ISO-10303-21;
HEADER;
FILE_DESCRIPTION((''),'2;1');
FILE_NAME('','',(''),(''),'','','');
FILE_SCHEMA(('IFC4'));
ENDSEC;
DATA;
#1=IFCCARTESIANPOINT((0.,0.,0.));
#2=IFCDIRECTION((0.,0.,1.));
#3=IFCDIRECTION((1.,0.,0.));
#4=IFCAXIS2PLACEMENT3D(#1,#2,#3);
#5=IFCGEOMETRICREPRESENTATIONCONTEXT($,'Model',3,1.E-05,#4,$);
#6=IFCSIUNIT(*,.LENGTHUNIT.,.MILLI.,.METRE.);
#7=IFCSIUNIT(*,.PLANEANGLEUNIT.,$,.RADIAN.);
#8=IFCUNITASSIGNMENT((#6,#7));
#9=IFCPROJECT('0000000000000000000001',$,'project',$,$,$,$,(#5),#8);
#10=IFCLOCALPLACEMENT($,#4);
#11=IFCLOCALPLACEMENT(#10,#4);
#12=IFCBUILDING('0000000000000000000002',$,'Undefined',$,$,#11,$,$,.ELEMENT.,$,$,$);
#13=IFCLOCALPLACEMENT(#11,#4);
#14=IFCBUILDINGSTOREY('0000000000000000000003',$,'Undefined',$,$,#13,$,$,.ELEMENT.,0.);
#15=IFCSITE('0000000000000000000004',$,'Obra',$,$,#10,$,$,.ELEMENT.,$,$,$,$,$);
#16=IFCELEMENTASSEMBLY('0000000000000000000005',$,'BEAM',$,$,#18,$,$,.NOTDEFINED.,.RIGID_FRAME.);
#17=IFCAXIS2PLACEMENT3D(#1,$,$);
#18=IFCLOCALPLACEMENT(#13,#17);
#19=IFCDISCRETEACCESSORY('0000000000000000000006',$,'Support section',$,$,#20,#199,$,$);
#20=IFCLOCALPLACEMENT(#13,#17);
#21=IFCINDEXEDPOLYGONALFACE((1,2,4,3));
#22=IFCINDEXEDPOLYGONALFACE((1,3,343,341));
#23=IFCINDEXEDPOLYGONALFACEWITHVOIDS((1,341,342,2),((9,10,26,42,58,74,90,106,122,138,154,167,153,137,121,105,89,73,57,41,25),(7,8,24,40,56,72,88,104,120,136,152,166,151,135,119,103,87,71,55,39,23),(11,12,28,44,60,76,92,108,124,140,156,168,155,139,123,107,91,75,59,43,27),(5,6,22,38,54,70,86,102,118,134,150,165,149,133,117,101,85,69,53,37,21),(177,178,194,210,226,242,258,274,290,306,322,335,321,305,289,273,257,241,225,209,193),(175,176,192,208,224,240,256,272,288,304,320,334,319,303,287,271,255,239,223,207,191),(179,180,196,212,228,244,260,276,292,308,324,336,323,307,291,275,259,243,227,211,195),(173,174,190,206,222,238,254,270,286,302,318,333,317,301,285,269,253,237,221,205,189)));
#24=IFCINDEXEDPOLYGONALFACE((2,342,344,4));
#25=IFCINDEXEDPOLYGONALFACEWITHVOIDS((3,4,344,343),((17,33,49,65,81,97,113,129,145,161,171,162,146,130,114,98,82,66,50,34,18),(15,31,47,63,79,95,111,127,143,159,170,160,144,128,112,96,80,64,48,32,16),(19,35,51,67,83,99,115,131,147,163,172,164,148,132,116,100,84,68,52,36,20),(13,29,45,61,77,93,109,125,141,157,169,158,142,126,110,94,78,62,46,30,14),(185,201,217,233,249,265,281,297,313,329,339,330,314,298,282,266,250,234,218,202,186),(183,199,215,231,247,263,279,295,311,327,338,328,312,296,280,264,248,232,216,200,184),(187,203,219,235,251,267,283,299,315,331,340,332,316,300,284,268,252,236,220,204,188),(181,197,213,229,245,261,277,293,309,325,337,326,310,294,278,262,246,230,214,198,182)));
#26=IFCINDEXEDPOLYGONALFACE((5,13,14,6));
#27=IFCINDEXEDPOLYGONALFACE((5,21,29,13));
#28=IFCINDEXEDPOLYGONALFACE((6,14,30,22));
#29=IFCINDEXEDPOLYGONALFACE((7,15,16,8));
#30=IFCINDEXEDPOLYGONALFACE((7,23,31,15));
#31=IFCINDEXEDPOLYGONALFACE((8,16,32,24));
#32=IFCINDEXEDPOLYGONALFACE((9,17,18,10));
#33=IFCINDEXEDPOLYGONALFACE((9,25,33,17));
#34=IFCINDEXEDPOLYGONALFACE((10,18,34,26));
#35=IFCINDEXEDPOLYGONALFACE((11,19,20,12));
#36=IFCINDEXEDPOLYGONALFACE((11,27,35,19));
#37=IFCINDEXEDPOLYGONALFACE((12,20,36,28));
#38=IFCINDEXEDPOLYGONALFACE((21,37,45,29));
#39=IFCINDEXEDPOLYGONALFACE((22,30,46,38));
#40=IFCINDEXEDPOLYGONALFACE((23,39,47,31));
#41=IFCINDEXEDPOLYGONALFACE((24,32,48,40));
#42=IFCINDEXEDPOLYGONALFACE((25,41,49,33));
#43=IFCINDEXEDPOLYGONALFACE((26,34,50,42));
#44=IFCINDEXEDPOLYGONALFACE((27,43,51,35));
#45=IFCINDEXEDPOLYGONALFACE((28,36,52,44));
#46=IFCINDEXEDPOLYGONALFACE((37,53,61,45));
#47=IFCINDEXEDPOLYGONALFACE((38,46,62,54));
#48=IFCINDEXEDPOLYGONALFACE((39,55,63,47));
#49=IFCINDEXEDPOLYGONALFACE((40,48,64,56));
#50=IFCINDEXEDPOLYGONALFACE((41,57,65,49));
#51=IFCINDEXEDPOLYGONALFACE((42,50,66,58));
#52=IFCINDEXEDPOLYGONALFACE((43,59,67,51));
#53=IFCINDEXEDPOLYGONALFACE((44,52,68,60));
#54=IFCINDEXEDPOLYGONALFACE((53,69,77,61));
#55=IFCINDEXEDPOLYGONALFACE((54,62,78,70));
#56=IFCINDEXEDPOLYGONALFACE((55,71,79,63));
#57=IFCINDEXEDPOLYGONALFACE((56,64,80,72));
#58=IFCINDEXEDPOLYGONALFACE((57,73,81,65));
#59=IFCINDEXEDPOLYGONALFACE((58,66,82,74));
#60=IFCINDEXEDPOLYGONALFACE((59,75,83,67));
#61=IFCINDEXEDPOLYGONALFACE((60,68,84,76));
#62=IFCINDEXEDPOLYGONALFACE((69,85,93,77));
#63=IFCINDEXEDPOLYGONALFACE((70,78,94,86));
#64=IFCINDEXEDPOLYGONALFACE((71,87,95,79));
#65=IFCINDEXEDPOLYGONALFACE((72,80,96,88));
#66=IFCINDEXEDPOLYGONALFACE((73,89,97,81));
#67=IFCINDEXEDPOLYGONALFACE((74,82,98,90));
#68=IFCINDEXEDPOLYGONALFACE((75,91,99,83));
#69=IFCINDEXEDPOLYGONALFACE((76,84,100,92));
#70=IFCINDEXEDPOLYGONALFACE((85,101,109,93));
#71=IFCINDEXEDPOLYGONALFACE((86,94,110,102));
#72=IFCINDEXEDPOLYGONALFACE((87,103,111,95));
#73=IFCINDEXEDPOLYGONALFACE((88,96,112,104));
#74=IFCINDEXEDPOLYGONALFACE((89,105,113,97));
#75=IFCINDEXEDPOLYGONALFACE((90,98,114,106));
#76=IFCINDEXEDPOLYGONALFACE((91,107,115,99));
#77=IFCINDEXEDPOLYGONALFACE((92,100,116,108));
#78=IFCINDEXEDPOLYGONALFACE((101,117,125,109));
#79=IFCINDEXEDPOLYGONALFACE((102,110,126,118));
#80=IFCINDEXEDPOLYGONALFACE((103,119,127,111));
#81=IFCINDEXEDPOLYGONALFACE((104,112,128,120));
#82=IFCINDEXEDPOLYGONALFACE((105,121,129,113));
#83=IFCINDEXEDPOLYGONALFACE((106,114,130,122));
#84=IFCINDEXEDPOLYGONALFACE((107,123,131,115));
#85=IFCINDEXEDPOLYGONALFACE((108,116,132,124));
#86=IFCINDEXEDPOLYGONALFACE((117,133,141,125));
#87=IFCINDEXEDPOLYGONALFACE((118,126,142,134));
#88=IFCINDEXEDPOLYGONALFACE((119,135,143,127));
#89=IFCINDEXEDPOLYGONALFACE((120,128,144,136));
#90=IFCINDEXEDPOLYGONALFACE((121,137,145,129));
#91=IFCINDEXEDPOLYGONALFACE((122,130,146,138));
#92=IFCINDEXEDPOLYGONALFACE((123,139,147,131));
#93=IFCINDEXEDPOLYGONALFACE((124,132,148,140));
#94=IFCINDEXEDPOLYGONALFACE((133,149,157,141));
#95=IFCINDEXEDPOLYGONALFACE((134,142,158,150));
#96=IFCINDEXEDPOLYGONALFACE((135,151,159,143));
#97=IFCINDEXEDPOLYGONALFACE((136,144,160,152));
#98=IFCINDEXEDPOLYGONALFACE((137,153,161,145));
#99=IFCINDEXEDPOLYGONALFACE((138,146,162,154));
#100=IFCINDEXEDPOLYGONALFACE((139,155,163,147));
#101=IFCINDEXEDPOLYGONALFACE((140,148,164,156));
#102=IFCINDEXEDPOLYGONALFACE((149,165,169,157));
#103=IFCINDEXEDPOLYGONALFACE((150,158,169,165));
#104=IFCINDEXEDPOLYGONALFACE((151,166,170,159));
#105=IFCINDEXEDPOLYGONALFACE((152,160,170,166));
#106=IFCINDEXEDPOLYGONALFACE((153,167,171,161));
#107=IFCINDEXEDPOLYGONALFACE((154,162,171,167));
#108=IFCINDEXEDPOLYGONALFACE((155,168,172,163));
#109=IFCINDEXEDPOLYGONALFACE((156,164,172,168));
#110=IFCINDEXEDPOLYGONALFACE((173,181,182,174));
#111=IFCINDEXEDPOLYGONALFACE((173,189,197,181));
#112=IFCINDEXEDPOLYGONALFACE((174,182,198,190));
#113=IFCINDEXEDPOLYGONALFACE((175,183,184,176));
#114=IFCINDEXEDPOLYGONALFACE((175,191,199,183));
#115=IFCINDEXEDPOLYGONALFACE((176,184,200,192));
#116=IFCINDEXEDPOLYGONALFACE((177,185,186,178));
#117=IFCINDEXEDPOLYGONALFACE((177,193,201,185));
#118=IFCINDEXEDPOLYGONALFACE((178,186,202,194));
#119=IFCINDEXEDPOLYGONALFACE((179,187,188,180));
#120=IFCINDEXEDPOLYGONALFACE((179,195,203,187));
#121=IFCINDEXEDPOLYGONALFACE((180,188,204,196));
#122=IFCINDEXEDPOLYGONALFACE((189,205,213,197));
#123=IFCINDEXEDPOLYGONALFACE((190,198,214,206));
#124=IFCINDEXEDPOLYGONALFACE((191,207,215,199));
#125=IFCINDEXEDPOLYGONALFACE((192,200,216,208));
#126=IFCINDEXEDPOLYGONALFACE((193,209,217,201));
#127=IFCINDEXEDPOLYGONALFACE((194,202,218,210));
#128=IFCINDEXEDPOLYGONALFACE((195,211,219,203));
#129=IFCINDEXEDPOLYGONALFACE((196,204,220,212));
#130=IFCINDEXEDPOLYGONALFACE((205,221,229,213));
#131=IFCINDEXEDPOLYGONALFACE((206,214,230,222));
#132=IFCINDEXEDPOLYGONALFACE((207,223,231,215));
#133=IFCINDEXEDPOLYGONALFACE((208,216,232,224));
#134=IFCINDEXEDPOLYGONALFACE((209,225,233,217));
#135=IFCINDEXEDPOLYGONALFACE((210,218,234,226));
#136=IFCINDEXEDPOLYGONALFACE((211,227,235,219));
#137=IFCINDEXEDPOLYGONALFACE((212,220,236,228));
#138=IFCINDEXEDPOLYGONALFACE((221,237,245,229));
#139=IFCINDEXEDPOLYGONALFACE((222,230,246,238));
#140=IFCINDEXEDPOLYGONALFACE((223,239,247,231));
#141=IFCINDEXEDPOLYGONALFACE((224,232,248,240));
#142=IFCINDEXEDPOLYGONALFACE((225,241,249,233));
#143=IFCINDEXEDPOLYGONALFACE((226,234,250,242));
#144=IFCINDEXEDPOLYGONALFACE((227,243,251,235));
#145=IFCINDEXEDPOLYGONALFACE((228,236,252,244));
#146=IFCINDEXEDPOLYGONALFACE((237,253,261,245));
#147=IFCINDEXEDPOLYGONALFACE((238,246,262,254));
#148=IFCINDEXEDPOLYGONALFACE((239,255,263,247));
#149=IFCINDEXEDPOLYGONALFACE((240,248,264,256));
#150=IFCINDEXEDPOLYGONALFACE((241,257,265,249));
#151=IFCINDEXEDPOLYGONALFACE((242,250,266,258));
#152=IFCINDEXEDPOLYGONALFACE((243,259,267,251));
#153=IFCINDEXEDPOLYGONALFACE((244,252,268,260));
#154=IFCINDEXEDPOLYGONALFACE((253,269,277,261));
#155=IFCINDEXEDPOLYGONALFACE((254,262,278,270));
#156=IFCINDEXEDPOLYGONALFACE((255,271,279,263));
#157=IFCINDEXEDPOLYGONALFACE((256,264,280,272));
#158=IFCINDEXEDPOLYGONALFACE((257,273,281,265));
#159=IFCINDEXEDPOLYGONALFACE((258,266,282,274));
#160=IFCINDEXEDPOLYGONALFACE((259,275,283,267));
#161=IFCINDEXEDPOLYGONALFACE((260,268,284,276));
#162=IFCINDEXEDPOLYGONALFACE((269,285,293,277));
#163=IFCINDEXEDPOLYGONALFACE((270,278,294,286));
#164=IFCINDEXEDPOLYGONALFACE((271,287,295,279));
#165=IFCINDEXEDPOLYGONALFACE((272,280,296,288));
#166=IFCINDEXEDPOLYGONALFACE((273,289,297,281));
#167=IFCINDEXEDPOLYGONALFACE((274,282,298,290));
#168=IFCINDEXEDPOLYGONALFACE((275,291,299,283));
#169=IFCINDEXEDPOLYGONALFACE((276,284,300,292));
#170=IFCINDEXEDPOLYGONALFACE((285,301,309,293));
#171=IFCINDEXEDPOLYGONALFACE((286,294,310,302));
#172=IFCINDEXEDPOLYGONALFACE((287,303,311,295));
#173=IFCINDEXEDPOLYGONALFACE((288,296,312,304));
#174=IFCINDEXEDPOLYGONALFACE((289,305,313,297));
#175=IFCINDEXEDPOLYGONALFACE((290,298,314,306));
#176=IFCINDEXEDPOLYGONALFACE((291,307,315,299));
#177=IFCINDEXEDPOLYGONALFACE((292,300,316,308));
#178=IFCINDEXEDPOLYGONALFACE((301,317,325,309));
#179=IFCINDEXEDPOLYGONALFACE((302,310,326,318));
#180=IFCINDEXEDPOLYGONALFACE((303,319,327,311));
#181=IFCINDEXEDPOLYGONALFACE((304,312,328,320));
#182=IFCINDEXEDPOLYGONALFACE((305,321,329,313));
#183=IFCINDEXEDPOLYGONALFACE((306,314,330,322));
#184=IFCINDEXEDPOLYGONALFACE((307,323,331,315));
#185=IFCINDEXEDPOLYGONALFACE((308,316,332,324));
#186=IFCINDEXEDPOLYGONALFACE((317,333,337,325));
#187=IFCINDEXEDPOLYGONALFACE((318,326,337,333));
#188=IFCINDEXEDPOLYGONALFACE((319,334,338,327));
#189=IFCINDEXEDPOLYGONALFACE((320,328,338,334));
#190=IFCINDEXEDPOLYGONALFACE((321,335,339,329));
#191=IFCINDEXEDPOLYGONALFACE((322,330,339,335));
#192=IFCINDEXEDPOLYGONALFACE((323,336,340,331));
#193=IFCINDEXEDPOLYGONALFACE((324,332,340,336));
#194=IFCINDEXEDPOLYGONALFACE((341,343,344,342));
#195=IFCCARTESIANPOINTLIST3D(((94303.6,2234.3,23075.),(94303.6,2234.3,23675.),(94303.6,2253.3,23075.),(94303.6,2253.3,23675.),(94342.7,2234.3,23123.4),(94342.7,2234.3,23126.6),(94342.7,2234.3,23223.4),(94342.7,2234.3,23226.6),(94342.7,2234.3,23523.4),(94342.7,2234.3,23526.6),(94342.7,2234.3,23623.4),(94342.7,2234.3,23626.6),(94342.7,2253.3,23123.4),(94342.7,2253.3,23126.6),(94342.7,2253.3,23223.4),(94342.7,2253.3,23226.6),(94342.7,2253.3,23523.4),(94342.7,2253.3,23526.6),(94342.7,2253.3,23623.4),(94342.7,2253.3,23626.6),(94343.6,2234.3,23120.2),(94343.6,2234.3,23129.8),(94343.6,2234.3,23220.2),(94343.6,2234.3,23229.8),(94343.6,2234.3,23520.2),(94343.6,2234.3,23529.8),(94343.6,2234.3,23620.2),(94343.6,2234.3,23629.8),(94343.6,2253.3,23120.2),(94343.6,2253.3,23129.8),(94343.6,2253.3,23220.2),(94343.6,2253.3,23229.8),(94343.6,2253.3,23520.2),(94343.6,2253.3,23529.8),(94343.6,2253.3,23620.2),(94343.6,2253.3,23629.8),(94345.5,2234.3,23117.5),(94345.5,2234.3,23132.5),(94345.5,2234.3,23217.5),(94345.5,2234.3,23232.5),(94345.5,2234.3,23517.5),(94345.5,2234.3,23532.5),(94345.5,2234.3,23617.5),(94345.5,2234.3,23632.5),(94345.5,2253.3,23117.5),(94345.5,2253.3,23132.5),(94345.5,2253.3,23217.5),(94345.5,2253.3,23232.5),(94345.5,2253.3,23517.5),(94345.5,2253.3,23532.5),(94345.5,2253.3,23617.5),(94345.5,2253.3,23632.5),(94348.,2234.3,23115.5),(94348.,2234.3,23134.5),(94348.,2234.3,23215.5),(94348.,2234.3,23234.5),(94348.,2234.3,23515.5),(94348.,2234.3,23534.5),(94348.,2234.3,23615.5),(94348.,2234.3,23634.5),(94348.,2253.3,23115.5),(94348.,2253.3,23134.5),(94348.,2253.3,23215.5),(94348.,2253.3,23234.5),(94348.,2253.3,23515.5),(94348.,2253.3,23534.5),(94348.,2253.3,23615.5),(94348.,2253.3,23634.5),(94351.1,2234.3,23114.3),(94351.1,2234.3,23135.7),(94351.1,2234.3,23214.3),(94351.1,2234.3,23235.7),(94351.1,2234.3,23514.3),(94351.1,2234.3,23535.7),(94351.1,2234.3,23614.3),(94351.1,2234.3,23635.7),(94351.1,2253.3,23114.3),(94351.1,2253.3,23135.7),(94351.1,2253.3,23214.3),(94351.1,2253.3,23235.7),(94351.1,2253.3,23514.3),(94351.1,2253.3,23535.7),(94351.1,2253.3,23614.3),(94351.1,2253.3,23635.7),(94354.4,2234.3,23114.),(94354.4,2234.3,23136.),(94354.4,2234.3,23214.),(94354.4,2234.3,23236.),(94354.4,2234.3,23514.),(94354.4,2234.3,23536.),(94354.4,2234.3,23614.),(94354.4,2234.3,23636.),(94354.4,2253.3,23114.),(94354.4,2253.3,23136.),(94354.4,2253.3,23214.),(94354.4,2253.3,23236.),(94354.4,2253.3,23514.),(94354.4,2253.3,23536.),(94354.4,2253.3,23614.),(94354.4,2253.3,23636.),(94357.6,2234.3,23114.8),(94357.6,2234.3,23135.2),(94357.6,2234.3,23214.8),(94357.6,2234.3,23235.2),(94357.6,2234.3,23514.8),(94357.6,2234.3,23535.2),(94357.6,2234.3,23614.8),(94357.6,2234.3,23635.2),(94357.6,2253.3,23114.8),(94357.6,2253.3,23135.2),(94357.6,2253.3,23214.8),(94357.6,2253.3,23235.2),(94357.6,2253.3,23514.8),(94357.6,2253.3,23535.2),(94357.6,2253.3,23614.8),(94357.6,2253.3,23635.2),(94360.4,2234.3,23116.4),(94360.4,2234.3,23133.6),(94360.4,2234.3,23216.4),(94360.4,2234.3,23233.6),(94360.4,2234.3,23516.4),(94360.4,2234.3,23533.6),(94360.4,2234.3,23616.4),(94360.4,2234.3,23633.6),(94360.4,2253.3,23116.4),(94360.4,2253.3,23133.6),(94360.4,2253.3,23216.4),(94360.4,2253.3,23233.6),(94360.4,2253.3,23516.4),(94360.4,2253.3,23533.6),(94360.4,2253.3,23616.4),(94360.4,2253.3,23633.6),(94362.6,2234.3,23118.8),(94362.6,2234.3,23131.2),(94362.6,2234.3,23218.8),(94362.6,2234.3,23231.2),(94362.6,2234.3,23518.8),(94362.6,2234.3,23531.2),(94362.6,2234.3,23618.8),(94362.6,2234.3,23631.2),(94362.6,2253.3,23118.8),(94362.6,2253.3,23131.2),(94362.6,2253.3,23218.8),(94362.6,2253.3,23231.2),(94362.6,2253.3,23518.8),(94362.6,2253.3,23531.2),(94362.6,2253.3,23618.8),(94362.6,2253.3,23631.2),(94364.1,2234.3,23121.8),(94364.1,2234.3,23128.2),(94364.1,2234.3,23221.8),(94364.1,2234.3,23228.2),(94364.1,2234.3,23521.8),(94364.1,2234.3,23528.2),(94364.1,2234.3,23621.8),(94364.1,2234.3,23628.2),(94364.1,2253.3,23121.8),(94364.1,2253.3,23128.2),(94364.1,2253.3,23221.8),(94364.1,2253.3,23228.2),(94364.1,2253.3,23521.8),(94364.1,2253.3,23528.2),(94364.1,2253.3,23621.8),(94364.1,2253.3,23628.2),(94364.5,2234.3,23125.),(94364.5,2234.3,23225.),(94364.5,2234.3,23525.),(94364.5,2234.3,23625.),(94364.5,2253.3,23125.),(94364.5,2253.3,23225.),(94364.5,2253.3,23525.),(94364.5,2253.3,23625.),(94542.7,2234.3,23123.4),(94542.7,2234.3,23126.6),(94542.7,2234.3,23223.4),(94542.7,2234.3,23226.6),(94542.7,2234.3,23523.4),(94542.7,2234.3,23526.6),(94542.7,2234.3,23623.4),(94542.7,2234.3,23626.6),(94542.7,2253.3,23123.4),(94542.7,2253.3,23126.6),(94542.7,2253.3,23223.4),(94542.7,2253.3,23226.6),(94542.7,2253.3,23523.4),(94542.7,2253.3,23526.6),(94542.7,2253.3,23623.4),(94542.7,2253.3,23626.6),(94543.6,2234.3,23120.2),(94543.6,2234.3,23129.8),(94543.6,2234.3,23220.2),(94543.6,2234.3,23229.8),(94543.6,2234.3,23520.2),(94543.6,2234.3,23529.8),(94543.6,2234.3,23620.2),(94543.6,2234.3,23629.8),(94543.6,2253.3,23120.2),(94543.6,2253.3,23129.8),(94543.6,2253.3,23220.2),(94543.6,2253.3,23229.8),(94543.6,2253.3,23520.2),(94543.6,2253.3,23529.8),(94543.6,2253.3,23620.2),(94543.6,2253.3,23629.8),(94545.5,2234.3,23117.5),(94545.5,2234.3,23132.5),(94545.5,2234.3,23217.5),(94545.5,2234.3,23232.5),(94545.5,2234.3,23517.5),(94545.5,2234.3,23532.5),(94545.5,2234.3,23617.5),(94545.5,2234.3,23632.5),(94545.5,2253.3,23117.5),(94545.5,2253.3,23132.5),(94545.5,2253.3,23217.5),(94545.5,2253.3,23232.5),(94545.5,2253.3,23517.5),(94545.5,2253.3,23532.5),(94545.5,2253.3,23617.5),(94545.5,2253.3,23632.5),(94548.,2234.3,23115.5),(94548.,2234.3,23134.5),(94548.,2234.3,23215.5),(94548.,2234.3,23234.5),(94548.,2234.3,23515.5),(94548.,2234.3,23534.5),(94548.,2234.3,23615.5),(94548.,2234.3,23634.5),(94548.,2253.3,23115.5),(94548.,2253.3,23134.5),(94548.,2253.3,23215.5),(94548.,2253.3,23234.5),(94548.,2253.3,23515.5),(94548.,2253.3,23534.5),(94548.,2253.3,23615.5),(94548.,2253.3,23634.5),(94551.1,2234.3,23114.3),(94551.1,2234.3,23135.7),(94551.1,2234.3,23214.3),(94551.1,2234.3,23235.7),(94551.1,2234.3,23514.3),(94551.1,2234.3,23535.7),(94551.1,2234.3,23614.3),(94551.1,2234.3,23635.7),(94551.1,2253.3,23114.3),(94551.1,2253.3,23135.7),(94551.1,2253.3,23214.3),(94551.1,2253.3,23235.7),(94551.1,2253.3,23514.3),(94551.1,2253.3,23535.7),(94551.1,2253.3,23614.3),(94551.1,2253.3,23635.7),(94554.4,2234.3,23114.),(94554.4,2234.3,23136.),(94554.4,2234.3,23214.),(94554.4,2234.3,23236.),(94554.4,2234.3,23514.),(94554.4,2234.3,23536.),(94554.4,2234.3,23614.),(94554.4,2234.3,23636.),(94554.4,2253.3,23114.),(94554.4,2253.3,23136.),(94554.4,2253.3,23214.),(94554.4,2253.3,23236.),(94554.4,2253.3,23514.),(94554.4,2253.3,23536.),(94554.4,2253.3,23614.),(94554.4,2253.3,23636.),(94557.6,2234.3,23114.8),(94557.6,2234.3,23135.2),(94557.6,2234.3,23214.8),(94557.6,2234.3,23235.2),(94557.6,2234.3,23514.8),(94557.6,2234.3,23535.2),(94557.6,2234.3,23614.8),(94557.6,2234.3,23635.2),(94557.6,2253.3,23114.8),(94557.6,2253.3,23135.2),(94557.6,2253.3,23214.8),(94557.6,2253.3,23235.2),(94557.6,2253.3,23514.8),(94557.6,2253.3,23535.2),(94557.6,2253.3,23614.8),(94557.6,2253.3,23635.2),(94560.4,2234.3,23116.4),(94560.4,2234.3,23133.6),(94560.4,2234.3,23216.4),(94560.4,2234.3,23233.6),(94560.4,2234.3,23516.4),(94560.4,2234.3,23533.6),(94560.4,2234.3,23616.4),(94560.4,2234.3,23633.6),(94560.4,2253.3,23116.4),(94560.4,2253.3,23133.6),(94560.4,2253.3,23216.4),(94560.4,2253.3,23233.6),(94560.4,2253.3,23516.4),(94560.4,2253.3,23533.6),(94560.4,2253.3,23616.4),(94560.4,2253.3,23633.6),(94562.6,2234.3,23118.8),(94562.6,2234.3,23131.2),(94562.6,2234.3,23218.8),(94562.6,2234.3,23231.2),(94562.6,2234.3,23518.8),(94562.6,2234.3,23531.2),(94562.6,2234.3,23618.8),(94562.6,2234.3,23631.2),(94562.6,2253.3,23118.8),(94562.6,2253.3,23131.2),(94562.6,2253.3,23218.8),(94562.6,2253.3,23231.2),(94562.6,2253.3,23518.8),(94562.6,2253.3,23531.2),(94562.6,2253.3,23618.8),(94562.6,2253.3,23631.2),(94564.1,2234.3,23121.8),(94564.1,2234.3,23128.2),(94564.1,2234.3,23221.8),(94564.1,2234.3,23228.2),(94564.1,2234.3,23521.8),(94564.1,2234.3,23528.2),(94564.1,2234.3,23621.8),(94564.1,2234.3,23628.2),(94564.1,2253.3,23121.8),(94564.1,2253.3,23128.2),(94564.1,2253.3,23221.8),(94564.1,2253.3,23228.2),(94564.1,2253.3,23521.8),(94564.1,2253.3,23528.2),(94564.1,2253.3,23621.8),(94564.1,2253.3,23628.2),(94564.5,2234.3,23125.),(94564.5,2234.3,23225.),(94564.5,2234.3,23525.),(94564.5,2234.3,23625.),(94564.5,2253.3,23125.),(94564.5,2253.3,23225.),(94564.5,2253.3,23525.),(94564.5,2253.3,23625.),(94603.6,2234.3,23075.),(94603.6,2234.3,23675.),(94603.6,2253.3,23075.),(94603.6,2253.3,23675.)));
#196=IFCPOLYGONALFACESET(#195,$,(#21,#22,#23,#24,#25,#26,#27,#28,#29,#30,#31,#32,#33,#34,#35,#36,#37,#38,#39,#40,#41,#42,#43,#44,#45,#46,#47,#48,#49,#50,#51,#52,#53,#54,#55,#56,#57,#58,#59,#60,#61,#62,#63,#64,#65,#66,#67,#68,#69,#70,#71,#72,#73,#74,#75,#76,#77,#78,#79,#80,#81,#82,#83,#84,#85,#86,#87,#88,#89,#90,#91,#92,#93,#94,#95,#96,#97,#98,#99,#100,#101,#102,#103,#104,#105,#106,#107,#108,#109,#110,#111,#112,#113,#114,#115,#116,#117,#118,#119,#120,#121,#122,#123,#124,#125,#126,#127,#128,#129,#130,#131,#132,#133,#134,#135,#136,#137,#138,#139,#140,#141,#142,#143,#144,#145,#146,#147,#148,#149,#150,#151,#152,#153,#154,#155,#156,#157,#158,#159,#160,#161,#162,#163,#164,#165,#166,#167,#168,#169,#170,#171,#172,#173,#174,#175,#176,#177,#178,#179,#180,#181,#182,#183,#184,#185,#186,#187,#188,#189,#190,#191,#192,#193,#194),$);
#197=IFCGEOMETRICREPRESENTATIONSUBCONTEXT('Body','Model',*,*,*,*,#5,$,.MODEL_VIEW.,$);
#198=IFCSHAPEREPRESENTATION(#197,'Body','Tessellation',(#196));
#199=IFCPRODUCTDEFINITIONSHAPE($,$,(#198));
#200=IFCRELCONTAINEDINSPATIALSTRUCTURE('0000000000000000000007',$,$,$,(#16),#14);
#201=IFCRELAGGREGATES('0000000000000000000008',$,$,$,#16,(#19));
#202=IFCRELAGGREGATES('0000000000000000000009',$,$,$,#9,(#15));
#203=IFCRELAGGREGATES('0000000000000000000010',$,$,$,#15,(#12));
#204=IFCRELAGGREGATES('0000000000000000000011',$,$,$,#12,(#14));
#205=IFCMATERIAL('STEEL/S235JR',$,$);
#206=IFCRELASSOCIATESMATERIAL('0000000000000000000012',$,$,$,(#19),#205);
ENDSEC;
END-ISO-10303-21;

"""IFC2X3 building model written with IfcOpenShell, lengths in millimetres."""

from ifc_helpers import new_model, si_unit, frame, origin_with_axes, origin_2d_with_axis, place, context, subcontext, project, spatial, rectangle, circle, extrude, source, transform, mapped, material, element, aggregate, save


model = new_model("IFC2X3")

# Units and contexts
model_context = context("Model", 3, precision=1e-05, world=origin_with_axes())
body_context = subcontext(model_context, "Body", "Model", "MODEL_VIEW")
ifc_project = project(units=[si_unit("LENGTHUNIT", "METRE", prefix="MILLI"), si_unit("PLANEANGLEUNIT", "RADIAN")], contexts=[model_context])

# Site, building, storey
site_placement = place(None, origin_with_axes())
site = spatial("IfcSite", under=ifc_project, at=site_placement, Name="Obra", CompositionType="ELEMENT")
building_placement = place(site_placement, origin_with_axes())
building = spatial("IfcBuilding", under=site, at=building_placement, Name="Undefined", CompositionType="ELEMENT")
storey_placement = place(building_placement, origin_with_axes())
storey = spatial("IfcBuildingStorey", under=building, at=storey_placement, Name="Undefined", CompositionType="ELEMENT", Elevation=0.0)

# Shared definitions
ifc_material_1 = material(Name="STEEL/S235JR")

# Element assembly, discrete accessory, opening
assembly_1_placement = place(storey_placement, origin_with_axes())
assembly_1 = element("IfcElementAssembly", 1, at=assembly_1_placement, inside=storey, Name="BEAM", AssemblyPlace="NOTDEFINED", PredefinedType="RIGID_FRAME")
discrete_accessory_1_placement = place(assembly_1_placement, frame((94603.6, 2243.8, 23375.0), z_axis=(0.0, 0.0, 1.0), x_axis=(-1.0, 0.0, 0.0)))
discrete_accessory_1 = element("IfcDiscreteAccessory", 2, at=discrete_accessory_1_placement, material=ifc_material_1, Name="Support section", context=body_context, shape_type="SweptSolid", body=[
    extrude(rectangle(XDim=19.0, YDim=600.0, at=origin_2d_with_axis()), frame((300.0, 0.0, 0.0), z_axis=(-1.0, 0.0, 0.0), x_axis=(0.0, -1.0, 0.0)), (0.0, 0.0, 1.0), 300.0),
])
shared_shape_1 = source(origin_with_axes(), body_context, "Body", "SweptSolid", [
    extrude(circle(Radius=11.0, at=origin_2d_with_axis()), frame((0.0, -19.1, 0.0), z_axis=(0.0, 1.0, 0.0), x_axis=(1.0, 0.0, 0.0)), (0.0, 0.0, 1.0), 19.2),
])
opening_1_placement = place(assembly_1_placement, frame((94358.5, 2253.3, 23375.0), z_axis=(0.0, 0.0, 1.0), x_axis=(1.0, 0.0, 0.0)))
element("IfcOpeningElement", 3, at=opening_1_placement, cuts=discrete_accessory_1, ObjectType="Opening", context=body_context, shape_type="MappedRepresentation", body=[
    mapped(shared_shape_1, transform((-5.0, 0.0, -250.0))),
    mapped(shared_shape_1, transform((-5.0, 0.0, -150.0))),
    mapped(shared_shape_1, transform((-5.0, 0.0, 150.0))),
    mapped(shared_shape_1, transform((-5.0, 0.0, 250.0))),
    mapped(shared_shape_1, transform((195.0, 0.0, -250.0))),
    mapped(shared_shape_1, transform((195.0, 0.0, -150.0))),
    mapped(shared_shape_1, transform((195.0, 0.0, 150.0))),
    mapped(shared_shape_1, transform((195.0, 0.0, 250.0))),
])
aggregate(assembly_1, [discrete_accessory_1])

save(model, "model.ifc")
